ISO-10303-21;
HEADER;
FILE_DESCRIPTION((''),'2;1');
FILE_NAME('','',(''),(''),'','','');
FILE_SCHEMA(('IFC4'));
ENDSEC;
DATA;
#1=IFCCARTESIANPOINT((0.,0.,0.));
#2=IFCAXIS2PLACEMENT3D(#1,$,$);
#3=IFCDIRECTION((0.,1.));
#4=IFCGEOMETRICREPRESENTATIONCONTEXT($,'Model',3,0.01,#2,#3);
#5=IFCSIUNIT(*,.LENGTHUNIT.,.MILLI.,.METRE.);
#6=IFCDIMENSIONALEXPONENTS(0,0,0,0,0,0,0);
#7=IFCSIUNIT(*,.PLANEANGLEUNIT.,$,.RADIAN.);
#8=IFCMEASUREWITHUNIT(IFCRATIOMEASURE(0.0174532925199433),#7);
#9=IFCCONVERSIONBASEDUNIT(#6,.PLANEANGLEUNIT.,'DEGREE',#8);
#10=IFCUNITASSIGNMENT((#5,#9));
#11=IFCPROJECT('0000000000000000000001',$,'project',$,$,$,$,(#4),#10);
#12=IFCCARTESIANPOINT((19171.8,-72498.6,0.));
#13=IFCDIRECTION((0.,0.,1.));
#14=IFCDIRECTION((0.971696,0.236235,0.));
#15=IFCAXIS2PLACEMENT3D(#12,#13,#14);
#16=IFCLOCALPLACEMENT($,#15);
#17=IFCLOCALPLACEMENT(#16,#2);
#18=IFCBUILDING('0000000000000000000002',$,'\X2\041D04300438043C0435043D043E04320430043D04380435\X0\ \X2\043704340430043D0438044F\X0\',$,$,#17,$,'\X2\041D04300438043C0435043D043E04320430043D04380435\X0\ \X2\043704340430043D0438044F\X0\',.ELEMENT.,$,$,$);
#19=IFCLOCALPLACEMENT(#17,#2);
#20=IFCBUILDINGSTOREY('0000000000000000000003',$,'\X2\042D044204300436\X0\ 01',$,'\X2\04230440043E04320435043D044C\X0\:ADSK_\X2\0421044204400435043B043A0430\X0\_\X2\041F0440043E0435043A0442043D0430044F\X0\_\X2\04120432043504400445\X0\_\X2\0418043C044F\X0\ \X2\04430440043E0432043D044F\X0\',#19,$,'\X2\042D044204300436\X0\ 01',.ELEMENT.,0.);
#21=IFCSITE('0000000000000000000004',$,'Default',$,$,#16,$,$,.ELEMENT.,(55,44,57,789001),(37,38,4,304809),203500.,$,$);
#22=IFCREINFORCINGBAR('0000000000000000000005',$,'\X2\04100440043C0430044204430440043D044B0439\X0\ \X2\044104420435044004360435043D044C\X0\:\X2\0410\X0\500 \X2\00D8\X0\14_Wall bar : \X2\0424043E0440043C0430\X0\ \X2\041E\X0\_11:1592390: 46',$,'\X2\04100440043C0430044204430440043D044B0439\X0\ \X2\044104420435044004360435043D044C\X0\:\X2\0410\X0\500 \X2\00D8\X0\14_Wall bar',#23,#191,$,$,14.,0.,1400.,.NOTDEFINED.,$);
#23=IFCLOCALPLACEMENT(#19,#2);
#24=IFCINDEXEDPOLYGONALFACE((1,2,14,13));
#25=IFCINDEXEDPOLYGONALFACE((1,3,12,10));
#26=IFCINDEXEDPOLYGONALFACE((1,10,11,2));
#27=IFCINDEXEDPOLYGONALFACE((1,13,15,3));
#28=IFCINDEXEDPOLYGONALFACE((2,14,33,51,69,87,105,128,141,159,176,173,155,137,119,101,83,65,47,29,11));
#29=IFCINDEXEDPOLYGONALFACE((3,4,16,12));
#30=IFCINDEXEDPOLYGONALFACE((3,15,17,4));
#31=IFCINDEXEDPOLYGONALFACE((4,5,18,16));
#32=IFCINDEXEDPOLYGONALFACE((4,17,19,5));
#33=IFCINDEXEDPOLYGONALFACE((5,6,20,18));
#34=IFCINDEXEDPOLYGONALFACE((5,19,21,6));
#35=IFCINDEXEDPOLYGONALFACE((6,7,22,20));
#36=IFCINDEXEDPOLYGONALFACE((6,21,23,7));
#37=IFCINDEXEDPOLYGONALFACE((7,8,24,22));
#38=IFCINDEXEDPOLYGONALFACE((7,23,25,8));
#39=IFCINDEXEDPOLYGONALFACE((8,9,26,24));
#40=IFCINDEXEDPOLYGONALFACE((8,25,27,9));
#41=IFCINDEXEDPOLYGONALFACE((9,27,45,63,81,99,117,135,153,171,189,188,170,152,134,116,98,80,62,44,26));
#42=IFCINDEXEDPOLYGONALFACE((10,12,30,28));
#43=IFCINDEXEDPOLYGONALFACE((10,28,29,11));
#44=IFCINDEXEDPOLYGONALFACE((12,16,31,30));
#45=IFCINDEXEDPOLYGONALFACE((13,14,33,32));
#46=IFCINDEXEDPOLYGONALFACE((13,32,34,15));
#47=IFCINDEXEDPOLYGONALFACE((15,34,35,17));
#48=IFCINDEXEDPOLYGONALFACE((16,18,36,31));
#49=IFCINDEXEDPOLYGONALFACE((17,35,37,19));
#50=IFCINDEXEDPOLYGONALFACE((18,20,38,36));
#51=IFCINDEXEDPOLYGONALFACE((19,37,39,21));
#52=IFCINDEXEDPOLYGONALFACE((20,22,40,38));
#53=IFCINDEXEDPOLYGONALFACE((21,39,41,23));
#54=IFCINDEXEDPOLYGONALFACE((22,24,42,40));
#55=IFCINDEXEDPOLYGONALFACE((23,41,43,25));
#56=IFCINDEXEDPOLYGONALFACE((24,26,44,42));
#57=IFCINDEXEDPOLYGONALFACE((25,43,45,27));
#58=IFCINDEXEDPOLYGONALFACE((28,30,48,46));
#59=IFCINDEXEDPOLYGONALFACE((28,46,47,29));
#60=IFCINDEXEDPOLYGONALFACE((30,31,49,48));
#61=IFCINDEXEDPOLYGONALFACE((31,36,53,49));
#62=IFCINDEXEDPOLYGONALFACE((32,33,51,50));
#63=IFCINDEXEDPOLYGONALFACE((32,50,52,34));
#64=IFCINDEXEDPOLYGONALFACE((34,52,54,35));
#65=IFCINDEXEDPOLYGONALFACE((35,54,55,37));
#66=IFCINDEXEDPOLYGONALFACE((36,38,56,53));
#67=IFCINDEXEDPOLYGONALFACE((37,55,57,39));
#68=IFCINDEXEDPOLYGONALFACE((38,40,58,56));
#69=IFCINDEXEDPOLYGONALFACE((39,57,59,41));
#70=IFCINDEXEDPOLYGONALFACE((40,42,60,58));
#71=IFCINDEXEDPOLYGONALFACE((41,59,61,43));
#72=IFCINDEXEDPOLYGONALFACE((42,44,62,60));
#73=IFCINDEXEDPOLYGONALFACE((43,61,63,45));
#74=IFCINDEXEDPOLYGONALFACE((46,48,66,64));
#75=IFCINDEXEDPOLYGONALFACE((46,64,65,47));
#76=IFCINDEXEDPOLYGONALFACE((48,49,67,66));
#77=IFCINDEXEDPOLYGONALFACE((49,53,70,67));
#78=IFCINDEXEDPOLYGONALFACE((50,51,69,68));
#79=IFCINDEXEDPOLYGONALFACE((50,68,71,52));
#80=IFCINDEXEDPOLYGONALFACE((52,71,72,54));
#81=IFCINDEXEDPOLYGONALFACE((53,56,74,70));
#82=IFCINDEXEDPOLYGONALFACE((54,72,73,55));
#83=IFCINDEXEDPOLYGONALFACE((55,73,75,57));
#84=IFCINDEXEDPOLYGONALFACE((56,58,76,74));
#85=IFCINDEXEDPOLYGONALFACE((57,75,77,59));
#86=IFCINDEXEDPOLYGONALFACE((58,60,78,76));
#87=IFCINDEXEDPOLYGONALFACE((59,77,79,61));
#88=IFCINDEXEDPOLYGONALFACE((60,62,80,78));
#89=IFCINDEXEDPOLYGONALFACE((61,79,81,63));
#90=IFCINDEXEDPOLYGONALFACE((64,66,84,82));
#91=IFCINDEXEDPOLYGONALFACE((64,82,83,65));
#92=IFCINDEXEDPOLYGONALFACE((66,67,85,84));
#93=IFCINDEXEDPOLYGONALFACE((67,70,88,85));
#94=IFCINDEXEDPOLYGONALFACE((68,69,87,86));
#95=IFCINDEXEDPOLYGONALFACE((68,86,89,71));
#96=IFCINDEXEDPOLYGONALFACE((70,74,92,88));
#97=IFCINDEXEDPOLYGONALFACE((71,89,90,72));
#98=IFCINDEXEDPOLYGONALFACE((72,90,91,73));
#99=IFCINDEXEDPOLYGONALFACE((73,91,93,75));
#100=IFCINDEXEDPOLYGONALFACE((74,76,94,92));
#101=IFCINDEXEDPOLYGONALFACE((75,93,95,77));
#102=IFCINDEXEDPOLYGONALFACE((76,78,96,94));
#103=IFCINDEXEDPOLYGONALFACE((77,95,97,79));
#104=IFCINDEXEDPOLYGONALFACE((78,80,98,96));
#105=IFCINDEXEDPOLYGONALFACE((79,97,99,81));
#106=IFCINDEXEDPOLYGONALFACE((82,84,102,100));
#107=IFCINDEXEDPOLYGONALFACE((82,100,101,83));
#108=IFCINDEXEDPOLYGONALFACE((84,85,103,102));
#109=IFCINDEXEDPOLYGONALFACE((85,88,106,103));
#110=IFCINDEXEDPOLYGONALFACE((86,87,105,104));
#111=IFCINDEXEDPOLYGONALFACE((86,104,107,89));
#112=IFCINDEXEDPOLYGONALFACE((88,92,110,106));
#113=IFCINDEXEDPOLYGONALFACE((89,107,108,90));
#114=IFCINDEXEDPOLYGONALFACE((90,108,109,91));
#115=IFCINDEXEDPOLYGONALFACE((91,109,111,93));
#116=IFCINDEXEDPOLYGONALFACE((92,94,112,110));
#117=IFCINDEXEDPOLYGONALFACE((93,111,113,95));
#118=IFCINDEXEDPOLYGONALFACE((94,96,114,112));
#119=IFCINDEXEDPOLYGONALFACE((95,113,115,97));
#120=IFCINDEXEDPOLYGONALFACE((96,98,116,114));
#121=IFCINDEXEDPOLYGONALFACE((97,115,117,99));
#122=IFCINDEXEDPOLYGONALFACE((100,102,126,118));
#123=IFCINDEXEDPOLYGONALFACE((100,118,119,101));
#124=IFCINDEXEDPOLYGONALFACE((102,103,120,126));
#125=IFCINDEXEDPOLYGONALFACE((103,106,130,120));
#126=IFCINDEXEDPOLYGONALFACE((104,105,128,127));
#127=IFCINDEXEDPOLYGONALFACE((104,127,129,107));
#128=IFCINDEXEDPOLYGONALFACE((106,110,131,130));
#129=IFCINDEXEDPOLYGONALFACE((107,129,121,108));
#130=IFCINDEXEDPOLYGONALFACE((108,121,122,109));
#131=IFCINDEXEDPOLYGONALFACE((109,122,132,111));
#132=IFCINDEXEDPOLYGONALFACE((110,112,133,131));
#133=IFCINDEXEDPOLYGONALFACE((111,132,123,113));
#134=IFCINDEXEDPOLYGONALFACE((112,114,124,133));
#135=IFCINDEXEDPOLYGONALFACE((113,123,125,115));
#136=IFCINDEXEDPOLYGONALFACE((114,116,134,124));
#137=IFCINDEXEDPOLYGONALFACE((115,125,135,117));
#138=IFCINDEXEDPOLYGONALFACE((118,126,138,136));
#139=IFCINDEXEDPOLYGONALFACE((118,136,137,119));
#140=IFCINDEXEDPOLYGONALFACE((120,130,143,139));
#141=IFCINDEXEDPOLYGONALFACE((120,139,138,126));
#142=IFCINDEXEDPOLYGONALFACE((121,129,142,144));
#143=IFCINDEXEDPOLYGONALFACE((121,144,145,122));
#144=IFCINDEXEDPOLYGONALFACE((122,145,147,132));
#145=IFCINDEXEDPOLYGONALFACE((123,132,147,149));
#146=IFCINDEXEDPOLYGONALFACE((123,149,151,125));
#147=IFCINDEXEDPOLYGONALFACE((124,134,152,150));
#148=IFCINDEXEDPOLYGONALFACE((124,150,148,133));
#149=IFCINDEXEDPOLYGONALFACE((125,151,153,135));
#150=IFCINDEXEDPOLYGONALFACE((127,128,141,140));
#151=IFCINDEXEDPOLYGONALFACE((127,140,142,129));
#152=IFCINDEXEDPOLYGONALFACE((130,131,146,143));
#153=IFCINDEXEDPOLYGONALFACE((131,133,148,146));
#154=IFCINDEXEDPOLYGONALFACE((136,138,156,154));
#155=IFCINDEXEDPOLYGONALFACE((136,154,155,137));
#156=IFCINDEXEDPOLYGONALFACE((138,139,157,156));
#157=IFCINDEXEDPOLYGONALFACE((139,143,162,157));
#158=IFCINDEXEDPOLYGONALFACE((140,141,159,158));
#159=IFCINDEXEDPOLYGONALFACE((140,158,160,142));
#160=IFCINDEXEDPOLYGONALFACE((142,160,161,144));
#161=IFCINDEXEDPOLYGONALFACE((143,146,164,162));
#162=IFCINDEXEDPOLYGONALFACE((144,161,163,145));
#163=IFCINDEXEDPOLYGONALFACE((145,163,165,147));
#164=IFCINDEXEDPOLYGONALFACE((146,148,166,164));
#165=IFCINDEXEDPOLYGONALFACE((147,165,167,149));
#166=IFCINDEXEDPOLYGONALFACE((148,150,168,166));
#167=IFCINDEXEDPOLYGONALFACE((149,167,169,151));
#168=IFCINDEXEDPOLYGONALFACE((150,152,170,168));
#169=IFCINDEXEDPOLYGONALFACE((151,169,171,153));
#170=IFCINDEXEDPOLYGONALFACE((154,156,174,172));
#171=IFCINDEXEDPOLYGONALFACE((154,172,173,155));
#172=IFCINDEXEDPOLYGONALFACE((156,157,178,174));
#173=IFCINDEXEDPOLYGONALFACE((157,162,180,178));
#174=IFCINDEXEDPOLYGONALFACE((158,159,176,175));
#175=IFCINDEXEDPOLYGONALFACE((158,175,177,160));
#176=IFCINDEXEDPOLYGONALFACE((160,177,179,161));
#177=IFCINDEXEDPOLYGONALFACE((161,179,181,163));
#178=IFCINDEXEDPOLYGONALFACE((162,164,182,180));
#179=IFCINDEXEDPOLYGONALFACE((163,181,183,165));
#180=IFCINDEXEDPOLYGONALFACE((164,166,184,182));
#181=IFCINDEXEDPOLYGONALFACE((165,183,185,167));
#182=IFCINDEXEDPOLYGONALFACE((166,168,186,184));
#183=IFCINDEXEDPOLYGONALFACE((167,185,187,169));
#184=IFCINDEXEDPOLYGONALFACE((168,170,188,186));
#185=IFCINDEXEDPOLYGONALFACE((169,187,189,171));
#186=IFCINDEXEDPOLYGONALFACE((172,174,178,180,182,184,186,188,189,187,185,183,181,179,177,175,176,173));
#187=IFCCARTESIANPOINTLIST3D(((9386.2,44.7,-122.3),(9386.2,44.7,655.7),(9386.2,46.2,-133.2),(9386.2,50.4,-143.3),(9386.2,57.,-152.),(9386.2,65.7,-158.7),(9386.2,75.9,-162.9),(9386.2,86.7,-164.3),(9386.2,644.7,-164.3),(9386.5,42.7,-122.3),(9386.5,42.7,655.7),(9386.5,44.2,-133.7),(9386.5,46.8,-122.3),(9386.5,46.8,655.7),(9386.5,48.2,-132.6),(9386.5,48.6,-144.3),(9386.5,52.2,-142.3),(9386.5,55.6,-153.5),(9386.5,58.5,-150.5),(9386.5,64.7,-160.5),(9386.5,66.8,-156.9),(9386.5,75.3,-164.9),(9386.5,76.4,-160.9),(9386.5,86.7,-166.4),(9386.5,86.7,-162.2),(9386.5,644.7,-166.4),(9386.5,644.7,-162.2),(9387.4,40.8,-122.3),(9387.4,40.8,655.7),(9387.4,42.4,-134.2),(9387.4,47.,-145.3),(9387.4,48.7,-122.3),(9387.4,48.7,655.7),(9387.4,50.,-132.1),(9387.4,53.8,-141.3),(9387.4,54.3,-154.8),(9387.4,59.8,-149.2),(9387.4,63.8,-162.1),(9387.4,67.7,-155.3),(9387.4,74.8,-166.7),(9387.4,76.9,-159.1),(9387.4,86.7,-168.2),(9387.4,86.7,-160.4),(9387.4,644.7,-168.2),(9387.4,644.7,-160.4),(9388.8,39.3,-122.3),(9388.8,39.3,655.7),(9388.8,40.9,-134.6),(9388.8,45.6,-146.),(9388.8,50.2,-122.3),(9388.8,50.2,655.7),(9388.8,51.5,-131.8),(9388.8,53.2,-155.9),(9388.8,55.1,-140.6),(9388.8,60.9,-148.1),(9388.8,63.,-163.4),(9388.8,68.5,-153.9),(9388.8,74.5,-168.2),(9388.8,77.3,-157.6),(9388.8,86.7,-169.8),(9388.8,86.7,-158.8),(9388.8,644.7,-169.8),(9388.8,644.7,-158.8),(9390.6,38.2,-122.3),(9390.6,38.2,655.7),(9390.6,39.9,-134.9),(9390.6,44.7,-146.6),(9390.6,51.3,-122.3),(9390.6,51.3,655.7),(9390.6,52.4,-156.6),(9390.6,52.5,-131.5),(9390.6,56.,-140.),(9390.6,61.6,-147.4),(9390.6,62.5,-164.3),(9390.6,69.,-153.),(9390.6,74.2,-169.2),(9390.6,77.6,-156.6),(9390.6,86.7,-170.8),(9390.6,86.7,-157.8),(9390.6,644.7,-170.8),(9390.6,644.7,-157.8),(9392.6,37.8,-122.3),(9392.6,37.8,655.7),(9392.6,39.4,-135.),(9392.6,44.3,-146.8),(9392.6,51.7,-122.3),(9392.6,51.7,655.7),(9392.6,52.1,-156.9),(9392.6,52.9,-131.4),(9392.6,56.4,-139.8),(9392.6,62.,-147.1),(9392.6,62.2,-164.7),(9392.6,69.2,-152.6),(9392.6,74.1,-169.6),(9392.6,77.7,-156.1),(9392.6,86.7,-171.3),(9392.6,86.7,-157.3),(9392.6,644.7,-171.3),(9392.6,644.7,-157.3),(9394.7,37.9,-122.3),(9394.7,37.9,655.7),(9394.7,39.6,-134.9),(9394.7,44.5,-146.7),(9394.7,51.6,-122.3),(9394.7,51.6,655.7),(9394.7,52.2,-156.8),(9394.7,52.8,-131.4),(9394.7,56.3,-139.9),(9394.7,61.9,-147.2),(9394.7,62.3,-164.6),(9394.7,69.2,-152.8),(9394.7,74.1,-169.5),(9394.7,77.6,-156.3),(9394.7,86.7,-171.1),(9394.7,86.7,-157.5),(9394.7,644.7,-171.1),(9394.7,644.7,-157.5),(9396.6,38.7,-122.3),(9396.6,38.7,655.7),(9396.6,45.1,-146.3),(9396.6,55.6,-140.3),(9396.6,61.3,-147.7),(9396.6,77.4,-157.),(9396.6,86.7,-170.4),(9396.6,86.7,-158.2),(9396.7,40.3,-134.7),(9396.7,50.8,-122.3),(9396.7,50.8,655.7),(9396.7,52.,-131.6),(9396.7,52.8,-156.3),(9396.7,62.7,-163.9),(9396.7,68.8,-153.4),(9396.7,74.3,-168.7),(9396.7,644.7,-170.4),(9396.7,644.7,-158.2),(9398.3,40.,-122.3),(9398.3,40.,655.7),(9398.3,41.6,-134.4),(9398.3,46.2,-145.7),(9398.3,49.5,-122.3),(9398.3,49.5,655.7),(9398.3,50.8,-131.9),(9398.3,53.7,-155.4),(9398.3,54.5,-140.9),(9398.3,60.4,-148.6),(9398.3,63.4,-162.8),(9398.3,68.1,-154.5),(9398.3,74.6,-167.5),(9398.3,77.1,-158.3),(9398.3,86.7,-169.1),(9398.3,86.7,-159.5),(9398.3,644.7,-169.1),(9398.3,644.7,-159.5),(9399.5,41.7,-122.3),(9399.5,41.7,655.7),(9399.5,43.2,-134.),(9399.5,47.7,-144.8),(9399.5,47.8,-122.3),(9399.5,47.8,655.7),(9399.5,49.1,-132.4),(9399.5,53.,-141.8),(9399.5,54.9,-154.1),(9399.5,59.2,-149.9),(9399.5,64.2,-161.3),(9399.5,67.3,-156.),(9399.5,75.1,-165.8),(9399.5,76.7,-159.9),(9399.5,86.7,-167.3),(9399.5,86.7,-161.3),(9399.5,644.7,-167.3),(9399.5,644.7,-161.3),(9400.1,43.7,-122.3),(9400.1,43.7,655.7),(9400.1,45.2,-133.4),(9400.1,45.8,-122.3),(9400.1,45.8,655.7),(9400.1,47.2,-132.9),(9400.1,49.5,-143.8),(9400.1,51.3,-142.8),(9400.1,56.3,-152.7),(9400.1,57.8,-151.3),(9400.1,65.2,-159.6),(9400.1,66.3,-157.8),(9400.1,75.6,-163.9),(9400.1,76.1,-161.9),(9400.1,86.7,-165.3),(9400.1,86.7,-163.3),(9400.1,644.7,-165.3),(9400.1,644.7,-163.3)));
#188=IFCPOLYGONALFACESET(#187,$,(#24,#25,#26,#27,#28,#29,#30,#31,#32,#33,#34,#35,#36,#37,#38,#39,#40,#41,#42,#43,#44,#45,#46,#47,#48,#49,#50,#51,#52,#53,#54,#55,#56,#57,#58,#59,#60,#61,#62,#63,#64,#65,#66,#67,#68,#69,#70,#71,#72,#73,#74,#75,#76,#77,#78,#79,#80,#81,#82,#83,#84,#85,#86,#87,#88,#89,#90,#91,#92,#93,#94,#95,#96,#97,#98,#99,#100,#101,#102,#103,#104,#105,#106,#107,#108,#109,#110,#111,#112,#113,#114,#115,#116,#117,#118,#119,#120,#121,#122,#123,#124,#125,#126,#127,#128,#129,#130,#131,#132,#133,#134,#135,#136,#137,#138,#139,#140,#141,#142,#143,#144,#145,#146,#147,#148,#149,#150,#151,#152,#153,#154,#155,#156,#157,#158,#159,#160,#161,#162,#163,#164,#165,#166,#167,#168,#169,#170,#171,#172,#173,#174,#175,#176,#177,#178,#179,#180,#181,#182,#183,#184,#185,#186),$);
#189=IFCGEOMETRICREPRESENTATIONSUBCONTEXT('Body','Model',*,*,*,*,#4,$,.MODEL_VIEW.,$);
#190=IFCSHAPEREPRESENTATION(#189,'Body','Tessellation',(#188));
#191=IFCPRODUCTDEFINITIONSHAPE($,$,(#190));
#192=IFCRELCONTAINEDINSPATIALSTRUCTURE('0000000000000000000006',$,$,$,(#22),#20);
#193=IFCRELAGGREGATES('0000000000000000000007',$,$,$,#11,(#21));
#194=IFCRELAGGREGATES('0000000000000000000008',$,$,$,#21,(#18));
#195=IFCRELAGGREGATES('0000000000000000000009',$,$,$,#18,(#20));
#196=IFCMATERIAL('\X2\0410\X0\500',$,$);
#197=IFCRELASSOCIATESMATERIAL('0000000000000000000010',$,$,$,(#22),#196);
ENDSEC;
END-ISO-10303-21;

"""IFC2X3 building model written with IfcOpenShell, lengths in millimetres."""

from ifc_helpers import new_model, entity, si_unit, converted_unit, direction, frame, origin, place, context, subcontext, project, spatial, material, element, save


model = new_model("IFC2X3")

# Units and contexts
model_context = context("Model", 3, precision=0.01, world=origin(), true_north=direction((0.0, 1.0)))
body_context = subcontext(model_context, "Body", "Model", "MODEL_VIEW")
ifc_project = project(units=[si_unit("LENGTHUNIT", "METRE", prefix="MILLI"), converted_unit("PLANEANGLEUNIT", "DEGREE", entity("IfcRatioMeasure", 0.0174532925199433), si_unit("PLANEANGLEUNIT", "RADIAN"), dimensions=[0, 0, 0, 0, 0, 0, 0])], contexts=[model_context])

# Site, building, storey
site_placement = place(None, frame((19171.8, -72498.6, 0.0), z_axis=(0.0, 0.0, 1.0), x_axis=(0.971696, 0.236235, 0.0)))
site = spatial("IfcSite", under=ifc_project, at=site_placement, Name="Default", CompositionType="ELEMENT", RefLatitude=(55, 44, 57, 789001), RefLongitude=(37, 38, 4, 304809), RefElevation=203500.0)
building_placement = place(site_placement, origin())
building = spatial("IfcBuilding", under=site, at=building_placement, Name="Наименование здания", LongName="Наименование здания", CompositionType="ELEMENT")
storey_placement = place(building_placement, origin())
storey = spatial("IfcBuildingStorey", under=building, at=storey_placement, Name="Этаж 01", ObjectType="Уровень:ADSK_Стрелка_Проектная_Вверх_Имя уровня", LongName="Этаж 01", CompositionType="ELEMENT", Elevation=0.0)

# Reinforcing bar
ifc_material = material(Name="А500")
placement = place(storey_placement, origin())
element("IfcReinforcingBar", 1, at=placement, inside=storey, material=ifc_material, Name="Арматурный стержень:А500 Ø14_Wall bar : Форма О_11:1592390: 46", ObjectType="Арматурный стержень:А500 Ø14_Wall bar", BarLength=1400.0, BarRole="NOTDEFINED", CrossSectionArea=0.0, NominalDiameter=14.0, context=body_context, shape_type="AdvancedSweptSolid", body=[
    entity("IfcSweptDiskSolid", entity("IfcCompositeCurve", [entity("IfcCompositeCurveSegment", "CONTINUOUS", True, entity("IfcPolyline", [entity("IfcCartesianPoint", [9393.1, 44.7, 655.7]), entity("IfcCartesianPoint", [9393.1, 44.7, -122.3])])), entity("IfcCompositeCurveSegment", "CONTINUOUS", True, entity("IfcTrimmedCurve", entity("IfcCircle", entity("IfcAxis2Placement3D", entity("IfcCartesianPoint", [9393.1, 86.7, -122.3]), entity("IfcDirection", [1.0, 0.0, 0.0]), entity("IfcDirection", [0.0, 0.0, -1.0])), 42.0), [entity("IfcParameterValue", 270.0)], [entity("IfcParameterValue", 360.0)], True, "PARAMETER")), entity("IfcCompositeCurveSegment", "CONTINUOUS", True, entity("IfcPolyline", [entity("IfcCartesianPoint", [9393.1, 86.7, -164.3]), entity("IfcCartesianPoint", [9393.1, 644.7, -164.3])]))], False), 7.0, None, 0.0, 92.0),
])

save(model, "model.ifc")
